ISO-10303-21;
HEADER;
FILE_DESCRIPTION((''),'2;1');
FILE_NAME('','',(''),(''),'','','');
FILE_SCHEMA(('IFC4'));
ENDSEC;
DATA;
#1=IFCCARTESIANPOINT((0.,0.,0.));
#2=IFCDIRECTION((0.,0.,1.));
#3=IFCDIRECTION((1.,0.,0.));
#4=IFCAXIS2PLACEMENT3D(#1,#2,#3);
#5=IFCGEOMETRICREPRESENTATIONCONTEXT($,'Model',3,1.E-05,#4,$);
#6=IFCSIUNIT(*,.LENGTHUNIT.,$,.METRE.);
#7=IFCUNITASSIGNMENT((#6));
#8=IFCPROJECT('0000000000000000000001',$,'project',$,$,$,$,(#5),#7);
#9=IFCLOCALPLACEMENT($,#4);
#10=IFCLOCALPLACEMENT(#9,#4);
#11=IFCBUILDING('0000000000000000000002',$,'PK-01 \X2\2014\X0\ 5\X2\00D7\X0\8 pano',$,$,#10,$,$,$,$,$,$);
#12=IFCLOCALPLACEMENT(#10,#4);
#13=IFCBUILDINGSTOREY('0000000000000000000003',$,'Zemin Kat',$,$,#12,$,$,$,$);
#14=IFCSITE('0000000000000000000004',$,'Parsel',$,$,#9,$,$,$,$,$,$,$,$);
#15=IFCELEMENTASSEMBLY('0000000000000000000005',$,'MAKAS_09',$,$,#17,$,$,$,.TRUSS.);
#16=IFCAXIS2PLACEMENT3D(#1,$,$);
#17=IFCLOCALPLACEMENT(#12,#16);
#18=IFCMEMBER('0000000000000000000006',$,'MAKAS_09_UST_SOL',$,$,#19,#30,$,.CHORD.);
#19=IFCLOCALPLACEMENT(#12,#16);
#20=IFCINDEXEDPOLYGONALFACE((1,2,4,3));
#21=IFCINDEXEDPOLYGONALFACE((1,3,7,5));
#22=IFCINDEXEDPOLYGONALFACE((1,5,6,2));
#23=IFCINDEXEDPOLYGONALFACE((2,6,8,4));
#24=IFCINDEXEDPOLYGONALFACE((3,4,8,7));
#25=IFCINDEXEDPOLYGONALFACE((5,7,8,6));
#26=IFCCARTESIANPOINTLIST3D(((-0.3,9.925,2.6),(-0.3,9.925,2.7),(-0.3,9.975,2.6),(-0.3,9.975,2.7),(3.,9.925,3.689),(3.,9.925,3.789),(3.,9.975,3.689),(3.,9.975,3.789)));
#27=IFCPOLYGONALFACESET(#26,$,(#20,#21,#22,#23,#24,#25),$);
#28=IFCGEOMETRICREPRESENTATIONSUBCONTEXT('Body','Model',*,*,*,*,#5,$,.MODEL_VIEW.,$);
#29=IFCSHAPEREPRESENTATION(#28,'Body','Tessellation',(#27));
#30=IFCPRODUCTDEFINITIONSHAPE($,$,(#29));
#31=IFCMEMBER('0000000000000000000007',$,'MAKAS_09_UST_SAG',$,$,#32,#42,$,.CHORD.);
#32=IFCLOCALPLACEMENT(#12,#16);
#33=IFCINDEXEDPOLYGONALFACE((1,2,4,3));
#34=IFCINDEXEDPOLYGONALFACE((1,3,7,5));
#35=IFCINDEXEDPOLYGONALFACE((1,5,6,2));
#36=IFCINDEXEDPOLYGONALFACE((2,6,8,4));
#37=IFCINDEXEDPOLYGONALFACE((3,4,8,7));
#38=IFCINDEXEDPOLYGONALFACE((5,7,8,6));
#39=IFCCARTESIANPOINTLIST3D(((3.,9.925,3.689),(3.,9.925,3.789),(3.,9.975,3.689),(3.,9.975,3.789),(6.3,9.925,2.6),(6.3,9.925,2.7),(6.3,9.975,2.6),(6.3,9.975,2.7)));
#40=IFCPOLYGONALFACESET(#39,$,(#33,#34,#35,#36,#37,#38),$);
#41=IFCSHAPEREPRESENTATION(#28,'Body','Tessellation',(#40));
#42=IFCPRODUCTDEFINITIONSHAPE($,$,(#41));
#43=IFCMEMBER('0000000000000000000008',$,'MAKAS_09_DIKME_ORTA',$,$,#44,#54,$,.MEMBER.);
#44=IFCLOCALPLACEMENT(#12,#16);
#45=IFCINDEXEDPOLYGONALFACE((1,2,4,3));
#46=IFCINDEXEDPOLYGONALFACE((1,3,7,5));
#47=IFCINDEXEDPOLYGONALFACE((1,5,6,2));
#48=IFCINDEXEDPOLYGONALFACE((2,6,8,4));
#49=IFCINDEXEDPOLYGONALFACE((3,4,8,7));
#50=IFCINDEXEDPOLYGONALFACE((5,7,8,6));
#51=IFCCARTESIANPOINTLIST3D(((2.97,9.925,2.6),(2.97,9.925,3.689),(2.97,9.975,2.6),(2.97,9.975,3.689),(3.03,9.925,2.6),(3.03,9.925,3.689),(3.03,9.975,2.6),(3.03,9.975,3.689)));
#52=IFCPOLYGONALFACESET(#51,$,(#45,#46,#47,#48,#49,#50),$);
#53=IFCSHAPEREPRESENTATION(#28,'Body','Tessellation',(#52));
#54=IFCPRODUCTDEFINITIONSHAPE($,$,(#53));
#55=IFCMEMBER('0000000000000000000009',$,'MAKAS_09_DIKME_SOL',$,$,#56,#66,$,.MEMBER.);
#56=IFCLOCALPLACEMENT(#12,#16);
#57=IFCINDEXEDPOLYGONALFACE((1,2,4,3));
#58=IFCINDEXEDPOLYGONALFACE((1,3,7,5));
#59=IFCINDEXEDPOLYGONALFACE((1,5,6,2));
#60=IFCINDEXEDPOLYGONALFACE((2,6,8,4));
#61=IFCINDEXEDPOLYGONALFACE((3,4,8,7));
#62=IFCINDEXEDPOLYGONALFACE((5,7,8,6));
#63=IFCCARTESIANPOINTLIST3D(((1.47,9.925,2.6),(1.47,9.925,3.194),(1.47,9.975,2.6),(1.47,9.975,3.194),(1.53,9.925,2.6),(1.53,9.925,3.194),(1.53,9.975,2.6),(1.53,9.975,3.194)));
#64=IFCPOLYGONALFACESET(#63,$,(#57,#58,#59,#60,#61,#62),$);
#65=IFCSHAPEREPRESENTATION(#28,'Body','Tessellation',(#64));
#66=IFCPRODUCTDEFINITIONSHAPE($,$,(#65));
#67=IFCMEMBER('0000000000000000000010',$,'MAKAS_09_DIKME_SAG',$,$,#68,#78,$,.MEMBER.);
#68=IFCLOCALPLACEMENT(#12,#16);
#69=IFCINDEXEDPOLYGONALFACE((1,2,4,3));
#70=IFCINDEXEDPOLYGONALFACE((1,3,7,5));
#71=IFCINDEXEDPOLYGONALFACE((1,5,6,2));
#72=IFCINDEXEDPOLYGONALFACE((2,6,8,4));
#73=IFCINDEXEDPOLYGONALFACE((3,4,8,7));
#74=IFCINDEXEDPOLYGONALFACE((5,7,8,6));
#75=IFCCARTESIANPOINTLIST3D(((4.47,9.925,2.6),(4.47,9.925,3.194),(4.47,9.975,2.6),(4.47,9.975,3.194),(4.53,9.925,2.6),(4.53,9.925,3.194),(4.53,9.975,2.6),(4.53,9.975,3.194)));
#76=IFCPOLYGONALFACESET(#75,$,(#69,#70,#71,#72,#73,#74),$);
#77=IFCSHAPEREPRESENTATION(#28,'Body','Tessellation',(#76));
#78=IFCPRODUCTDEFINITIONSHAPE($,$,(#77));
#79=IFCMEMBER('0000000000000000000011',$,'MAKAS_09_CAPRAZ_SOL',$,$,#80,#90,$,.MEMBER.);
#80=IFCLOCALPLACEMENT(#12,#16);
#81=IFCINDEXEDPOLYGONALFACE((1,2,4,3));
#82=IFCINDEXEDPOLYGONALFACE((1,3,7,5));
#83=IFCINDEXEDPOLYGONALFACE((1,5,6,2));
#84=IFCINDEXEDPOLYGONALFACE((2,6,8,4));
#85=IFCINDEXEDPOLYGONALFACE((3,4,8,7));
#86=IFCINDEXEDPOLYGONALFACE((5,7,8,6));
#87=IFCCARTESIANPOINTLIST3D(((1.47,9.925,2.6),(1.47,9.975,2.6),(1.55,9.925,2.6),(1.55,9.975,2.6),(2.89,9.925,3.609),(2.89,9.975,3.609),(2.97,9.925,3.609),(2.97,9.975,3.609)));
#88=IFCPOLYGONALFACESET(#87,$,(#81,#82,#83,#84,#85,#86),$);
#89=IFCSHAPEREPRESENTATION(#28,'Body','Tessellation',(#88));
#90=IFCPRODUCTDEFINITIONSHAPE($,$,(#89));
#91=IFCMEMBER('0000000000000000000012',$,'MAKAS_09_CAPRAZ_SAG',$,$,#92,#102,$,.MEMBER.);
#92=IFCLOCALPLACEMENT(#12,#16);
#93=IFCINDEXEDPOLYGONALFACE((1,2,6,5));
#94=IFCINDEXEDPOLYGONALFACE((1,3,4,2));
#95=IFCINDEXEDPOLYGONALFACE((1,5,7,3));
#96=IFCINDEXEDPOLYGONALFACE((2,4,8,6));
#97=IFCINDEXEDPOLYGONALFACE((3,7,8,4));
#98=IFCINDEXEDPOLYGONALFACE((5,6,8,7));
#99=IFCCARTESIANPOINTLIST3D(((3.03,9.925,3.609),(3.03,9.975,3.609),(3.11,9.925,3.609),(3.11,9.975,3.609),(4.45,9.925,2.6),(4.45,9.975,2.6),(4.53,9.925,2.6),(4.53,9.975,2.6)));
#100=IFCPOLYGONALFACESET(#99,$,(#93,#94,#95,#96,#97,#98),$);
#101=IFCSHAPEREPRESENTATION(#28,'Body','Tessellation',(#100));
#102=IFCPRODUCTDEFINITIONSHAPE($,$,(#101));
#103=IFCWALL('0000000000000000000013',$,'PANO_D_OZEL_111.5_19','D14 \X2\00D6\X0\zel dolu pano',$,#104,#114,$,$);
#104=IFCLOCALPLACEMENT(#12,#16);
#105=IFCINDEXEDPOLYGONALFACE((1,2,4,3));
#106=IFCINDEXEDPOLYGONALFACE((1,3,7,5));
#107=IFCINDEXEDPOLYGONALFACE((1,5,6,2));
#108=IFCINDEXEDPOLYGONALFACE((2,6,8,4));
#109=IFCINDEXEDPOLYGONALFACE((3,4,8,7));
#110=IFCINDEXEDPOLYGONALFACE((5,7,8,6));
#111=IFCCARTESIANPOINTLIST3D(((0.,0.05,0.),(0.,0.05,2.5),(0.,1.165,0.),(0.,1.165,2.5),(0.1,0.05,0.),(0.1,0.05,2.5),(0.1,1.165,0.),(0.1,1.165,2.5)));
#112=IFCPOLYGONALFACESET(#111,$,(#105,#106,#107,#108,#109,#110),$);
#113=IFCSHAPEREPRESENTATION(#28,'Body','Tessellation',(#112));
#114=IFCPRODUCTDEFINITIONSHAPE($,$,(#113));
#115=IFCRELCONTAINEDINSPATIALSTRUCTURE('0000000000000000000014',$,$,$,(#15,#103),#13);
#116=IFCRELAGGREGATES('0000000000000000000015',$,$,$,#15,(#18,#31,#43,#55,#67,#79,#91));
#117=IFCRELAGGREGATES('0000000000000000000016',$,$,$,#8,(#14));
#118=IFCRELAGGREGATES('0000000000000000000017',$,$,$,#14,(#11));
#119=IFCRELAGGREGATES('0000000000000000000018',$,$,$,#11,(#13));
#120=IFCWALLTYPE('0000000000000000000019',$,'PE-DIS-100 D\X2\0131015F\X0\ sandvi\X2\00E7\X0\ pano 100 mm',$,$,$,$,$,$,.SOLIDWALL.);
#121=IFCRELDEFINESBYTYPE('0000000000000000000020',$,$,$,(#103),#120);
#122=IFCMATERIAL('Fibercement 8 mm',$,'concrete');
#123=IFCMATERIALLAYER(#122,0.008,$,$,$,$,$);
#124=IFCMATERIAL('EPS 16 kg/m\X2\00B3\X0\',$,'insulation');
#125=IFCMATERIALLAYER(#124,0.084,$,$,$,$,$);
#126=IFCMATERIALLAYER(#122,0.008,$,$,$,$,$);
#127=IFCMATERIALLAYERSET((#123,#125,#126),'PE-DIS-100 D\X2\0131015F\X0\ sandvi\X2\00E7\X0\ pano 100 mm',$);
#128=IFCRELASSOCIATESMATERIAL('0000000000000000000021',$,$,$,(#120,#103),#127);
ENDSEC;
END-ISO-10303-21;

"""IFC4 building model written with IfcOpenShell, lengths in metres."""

from ifc_helpers import new_model, si_unit, frame, origin_with_axes, place, context, subcontext, project, spatial, line, indexed_curve, outline, extrude, material, layer, layer_set, layer_usage, type_object, element, aggregate, save


model = new_model("IFC4")

# Units and contexts
model_context = context("Model", 3, precision=1e-05, world=origin_with_axes())
body_context = subcontext(model_context, "Body", "Model", "MODEL_VIEW")
ifc_project = project(units=[si_unit("LENGTHUNIT", "METRE")], contexts=[model_context])

# Site, building, storey
site_placement = place(None, origin_with_axes())
site = spatial("IfcSite", under=ifc_project, at=site_placement, Name="Parsel")
building_placement = place(site_placement, origin_with_axes())
building = spatial("IfcBuilding", under=site, at=building_placement, Name="PK-01 — 5×8 pano")
storey_placement = place(building_placement, origin_with_axes())
storey = spatial("IfcBuildingStorey", under=building, at=storey_placement, Name="Zemin Kat")

# Element assembly, members
assembly_1_placement = place(storey_placement, origin_with_axes())
assembly_1 = element("IfcElementAssembly", 1, at=assembly_1_placement, inside=storey, Name="MAKAS_09", PredefinedType="TRUSS")
member_1_placement = place(assembly_1_placement, origin_with_axes())
member_1 = element("IfcMember", 2, at=member_1_placement, Name="MAKAS_09_UST_SOL", PredefinedType="CHORD", context=body_context, shape_type="SweptSolid", body=[
    extrude(outline(indexed_curve([(-0.3, 2.6), (3.0, 3.689), (3.0, 3.789), (-0.3, 2.7)], segments=[line(1, 2, 3, 4, 1)])), frame((0.0, 9.975, 0.0), z_axis=(0.0, -1.0, 0.0), x_axis=(1.0, 0.0, 0.0)), (0.0, 0.0, 1.0), 0.05),
])
member_2_placement = place(assembly_1_placement, origin_with_axes())
member_2 = element("IfcMember", 3, at=member_2_placement, Name="MAKAS_09_UST_SAG", PredefinedType="CHORD", context=body_context, shape_type="SweptSolid", body=[
    extrude(outline(indexed_curve([(3.0, 3.689), (6.3, 2.6), (6.3, 2.7), (3.0, 3.789)], segments=[line(1, 2, 3, 4, 1)])), frame((0.0, 9.975, 0.0), z_axis=(0.0, -1.0, 0.0), x_axis=(1.0, 0.0, 0.0)), (0.0, 0.0, 1.0), 0.05),
])
member_3_placement = place(assembly_1_placement, origin_with_axes())
member_3 = element("IfcMember", 4, at=member_3_placement, Name="MAKAS_09_DIKME_ORTA", PredefinedType="MEMBER", context=body_context, shape_type="SweptSolid", body=[
    extrude(outline(indexed_curve([(2.97, 2.6), (3.03, 2.6), (3.03, 3.689), (2.97, 3.689)], segments=[line(1, 2, 3, 4, 1)])), frame((0.0, 9.975, 0.0), z_axis=(0.0, -1.0, 0.0), x_axis=(1.0, 0.0, 0.0)), (0.0, 0.0, 1.0), 0.05),
])
member_4_placement = place(assembly_1_placement, origin_with_axes())
member_4 = element("IfcMember", 5, at=member_4_placement, Name="MAKAS_09_DIKME_SOL", PredefinedType="MEMBER", context=body_context, shape_type="SweptSolid", body=[
    extrude(outline(indexed_curve([(1.47, 2.6), (1.53, 2.6), (1.53, 3.194), (1.47, 3.194)], segments=[line(1, 2, 3, 4, 1)])), frame((0.0, 9.975, 0.0), z_axis=(0.0, -1.0, 0.0), x_axis=(1.0, 0.0, 0.0)), (0.0, 0.0, 1.0), 0.05),
])
member_5_placement = place(assembly_1_placement, origin_with_axes())
member_5 = element("IfcMember", 6, at=member_5_placement, Name="MAKAS_09_DIKME_SAG", PredefinedType="MEMBER", context=body_context, shape_type="SweptSolid", body=[
    extrude(outline(indexed_curve([(4.47, 2.6), (4.53, 2.6), (4.53, 3.194), (4.47, 3.194)], segments=[line(1, 2, 3, 4, 1)])), frame((0.0, 9.975, 0.0), z_axis=(0.0, -1.0, 0.0), x_axis=(1.0, 0.0, 0.0)), (0.0, 0.0, 1.0), 0.05),
])
member_6_placement = place(assembly_1_placement, origin_with_axes())
member_6 = element("IfcMember", 7, at=member_6_placement, Name="MAKAS_09_CAPRAZ_SOL", PredefinedType="MEMBER", context=body_context, shape_type="SweptSolid", body=[
    extrude(outline(indexed_curve([(1.47, 2.6), (1.55, 2.6), (2.97, 3.609), (2.89, 3.609)], segments=[line(1, 2, 3, 4, 1)])), frame((0.0, 9.975, 0.0), z_axis=(0.0, -1.0, 0.0), x_axis=(1.0, 0.0, 0.0)), (0.0, 0.0, 1.0), 0.05),
])
member_7_placement = place(assembly_1_placement, origin_with_axes())
member_7 = element("IfcMember", 8, at=member_7_placement, Name="MAKAS_09_CAPRAZ_SAG", PredefinedType="MEMBER", context=body_context, shape_type="SweptSolid", body=[
    extrude(outline(indexed_curve([(4.45, 2.6), (4.53, 2.6), (3.11, 3.609), (3.03, 3.609)], segments=[line(1, 2, 3, 4, 1)])), frame((0.0, 9.975, 0.0), z_axis=(0.0, -1.0, 0.0), x_axis=(1.0, 0.0, 0.0)), (0.0, 0.0, 1.0), 0.05),
])
aggregate(assembly_1, [member_1, member_2, member_3, member_4, member_5, member_6, member_7])

# Wall
ifc_material_1 = material(Name="Fibercement 8 mm", Category="concrete")
ifc_layer_1 = layer(ifc_material_1, 0.008)
ifc_material_2 = material(Name="EPS 16 kg/m³", Category="insulation")
ifc_layer_2 = layer(ifc_material_2, 0.084)
ifc_layer_3 = layer(ifc_material_1, 0.008)
ifc_layer_set = layer_set([ifc_layer_1, ifc_layer_2, ifc_layer_3], Name="PE-DIS-100 Dış sandviç pano 100 mm")
ifc_layer_usage = layer_usage(ifc_layer_set, "AXIS2", "POSITIVE", 0.0)
wall_type = type_object("IfcWallType", Name="PE-DIS-100 Dış sandviç pano 100 mm", PredefinedType="SOLIDWALL", material=ifc_layer_set)
wall_placement = place(storey_placement, frame((0.1, 0.05, 0.0), z_axis=(0.0, 0.0, 1.0), x_axis=(0.0, 1.0, 0.0)))
element("IfcWall", 9, at=wall_placement, inside=storey, type_object=wall_type, material=ifc_layer_usage, Name="PANO_D_OZEL_111.5_19", Description="D14 Özel dolu pano", context=body_context, shape_type="SweptSolid", body=[
    extrude(outline(indexed_curve([(0.0, 0.0), (1.115, 0.0), (1.115, 0.1), (0.0, 0.1)], segments=[line(1, 2, 3, 4, 1)])), origin_with_axes(), (0.0, 0.0, 1.0), 2.5),
])

save(model, "model.ifc")
